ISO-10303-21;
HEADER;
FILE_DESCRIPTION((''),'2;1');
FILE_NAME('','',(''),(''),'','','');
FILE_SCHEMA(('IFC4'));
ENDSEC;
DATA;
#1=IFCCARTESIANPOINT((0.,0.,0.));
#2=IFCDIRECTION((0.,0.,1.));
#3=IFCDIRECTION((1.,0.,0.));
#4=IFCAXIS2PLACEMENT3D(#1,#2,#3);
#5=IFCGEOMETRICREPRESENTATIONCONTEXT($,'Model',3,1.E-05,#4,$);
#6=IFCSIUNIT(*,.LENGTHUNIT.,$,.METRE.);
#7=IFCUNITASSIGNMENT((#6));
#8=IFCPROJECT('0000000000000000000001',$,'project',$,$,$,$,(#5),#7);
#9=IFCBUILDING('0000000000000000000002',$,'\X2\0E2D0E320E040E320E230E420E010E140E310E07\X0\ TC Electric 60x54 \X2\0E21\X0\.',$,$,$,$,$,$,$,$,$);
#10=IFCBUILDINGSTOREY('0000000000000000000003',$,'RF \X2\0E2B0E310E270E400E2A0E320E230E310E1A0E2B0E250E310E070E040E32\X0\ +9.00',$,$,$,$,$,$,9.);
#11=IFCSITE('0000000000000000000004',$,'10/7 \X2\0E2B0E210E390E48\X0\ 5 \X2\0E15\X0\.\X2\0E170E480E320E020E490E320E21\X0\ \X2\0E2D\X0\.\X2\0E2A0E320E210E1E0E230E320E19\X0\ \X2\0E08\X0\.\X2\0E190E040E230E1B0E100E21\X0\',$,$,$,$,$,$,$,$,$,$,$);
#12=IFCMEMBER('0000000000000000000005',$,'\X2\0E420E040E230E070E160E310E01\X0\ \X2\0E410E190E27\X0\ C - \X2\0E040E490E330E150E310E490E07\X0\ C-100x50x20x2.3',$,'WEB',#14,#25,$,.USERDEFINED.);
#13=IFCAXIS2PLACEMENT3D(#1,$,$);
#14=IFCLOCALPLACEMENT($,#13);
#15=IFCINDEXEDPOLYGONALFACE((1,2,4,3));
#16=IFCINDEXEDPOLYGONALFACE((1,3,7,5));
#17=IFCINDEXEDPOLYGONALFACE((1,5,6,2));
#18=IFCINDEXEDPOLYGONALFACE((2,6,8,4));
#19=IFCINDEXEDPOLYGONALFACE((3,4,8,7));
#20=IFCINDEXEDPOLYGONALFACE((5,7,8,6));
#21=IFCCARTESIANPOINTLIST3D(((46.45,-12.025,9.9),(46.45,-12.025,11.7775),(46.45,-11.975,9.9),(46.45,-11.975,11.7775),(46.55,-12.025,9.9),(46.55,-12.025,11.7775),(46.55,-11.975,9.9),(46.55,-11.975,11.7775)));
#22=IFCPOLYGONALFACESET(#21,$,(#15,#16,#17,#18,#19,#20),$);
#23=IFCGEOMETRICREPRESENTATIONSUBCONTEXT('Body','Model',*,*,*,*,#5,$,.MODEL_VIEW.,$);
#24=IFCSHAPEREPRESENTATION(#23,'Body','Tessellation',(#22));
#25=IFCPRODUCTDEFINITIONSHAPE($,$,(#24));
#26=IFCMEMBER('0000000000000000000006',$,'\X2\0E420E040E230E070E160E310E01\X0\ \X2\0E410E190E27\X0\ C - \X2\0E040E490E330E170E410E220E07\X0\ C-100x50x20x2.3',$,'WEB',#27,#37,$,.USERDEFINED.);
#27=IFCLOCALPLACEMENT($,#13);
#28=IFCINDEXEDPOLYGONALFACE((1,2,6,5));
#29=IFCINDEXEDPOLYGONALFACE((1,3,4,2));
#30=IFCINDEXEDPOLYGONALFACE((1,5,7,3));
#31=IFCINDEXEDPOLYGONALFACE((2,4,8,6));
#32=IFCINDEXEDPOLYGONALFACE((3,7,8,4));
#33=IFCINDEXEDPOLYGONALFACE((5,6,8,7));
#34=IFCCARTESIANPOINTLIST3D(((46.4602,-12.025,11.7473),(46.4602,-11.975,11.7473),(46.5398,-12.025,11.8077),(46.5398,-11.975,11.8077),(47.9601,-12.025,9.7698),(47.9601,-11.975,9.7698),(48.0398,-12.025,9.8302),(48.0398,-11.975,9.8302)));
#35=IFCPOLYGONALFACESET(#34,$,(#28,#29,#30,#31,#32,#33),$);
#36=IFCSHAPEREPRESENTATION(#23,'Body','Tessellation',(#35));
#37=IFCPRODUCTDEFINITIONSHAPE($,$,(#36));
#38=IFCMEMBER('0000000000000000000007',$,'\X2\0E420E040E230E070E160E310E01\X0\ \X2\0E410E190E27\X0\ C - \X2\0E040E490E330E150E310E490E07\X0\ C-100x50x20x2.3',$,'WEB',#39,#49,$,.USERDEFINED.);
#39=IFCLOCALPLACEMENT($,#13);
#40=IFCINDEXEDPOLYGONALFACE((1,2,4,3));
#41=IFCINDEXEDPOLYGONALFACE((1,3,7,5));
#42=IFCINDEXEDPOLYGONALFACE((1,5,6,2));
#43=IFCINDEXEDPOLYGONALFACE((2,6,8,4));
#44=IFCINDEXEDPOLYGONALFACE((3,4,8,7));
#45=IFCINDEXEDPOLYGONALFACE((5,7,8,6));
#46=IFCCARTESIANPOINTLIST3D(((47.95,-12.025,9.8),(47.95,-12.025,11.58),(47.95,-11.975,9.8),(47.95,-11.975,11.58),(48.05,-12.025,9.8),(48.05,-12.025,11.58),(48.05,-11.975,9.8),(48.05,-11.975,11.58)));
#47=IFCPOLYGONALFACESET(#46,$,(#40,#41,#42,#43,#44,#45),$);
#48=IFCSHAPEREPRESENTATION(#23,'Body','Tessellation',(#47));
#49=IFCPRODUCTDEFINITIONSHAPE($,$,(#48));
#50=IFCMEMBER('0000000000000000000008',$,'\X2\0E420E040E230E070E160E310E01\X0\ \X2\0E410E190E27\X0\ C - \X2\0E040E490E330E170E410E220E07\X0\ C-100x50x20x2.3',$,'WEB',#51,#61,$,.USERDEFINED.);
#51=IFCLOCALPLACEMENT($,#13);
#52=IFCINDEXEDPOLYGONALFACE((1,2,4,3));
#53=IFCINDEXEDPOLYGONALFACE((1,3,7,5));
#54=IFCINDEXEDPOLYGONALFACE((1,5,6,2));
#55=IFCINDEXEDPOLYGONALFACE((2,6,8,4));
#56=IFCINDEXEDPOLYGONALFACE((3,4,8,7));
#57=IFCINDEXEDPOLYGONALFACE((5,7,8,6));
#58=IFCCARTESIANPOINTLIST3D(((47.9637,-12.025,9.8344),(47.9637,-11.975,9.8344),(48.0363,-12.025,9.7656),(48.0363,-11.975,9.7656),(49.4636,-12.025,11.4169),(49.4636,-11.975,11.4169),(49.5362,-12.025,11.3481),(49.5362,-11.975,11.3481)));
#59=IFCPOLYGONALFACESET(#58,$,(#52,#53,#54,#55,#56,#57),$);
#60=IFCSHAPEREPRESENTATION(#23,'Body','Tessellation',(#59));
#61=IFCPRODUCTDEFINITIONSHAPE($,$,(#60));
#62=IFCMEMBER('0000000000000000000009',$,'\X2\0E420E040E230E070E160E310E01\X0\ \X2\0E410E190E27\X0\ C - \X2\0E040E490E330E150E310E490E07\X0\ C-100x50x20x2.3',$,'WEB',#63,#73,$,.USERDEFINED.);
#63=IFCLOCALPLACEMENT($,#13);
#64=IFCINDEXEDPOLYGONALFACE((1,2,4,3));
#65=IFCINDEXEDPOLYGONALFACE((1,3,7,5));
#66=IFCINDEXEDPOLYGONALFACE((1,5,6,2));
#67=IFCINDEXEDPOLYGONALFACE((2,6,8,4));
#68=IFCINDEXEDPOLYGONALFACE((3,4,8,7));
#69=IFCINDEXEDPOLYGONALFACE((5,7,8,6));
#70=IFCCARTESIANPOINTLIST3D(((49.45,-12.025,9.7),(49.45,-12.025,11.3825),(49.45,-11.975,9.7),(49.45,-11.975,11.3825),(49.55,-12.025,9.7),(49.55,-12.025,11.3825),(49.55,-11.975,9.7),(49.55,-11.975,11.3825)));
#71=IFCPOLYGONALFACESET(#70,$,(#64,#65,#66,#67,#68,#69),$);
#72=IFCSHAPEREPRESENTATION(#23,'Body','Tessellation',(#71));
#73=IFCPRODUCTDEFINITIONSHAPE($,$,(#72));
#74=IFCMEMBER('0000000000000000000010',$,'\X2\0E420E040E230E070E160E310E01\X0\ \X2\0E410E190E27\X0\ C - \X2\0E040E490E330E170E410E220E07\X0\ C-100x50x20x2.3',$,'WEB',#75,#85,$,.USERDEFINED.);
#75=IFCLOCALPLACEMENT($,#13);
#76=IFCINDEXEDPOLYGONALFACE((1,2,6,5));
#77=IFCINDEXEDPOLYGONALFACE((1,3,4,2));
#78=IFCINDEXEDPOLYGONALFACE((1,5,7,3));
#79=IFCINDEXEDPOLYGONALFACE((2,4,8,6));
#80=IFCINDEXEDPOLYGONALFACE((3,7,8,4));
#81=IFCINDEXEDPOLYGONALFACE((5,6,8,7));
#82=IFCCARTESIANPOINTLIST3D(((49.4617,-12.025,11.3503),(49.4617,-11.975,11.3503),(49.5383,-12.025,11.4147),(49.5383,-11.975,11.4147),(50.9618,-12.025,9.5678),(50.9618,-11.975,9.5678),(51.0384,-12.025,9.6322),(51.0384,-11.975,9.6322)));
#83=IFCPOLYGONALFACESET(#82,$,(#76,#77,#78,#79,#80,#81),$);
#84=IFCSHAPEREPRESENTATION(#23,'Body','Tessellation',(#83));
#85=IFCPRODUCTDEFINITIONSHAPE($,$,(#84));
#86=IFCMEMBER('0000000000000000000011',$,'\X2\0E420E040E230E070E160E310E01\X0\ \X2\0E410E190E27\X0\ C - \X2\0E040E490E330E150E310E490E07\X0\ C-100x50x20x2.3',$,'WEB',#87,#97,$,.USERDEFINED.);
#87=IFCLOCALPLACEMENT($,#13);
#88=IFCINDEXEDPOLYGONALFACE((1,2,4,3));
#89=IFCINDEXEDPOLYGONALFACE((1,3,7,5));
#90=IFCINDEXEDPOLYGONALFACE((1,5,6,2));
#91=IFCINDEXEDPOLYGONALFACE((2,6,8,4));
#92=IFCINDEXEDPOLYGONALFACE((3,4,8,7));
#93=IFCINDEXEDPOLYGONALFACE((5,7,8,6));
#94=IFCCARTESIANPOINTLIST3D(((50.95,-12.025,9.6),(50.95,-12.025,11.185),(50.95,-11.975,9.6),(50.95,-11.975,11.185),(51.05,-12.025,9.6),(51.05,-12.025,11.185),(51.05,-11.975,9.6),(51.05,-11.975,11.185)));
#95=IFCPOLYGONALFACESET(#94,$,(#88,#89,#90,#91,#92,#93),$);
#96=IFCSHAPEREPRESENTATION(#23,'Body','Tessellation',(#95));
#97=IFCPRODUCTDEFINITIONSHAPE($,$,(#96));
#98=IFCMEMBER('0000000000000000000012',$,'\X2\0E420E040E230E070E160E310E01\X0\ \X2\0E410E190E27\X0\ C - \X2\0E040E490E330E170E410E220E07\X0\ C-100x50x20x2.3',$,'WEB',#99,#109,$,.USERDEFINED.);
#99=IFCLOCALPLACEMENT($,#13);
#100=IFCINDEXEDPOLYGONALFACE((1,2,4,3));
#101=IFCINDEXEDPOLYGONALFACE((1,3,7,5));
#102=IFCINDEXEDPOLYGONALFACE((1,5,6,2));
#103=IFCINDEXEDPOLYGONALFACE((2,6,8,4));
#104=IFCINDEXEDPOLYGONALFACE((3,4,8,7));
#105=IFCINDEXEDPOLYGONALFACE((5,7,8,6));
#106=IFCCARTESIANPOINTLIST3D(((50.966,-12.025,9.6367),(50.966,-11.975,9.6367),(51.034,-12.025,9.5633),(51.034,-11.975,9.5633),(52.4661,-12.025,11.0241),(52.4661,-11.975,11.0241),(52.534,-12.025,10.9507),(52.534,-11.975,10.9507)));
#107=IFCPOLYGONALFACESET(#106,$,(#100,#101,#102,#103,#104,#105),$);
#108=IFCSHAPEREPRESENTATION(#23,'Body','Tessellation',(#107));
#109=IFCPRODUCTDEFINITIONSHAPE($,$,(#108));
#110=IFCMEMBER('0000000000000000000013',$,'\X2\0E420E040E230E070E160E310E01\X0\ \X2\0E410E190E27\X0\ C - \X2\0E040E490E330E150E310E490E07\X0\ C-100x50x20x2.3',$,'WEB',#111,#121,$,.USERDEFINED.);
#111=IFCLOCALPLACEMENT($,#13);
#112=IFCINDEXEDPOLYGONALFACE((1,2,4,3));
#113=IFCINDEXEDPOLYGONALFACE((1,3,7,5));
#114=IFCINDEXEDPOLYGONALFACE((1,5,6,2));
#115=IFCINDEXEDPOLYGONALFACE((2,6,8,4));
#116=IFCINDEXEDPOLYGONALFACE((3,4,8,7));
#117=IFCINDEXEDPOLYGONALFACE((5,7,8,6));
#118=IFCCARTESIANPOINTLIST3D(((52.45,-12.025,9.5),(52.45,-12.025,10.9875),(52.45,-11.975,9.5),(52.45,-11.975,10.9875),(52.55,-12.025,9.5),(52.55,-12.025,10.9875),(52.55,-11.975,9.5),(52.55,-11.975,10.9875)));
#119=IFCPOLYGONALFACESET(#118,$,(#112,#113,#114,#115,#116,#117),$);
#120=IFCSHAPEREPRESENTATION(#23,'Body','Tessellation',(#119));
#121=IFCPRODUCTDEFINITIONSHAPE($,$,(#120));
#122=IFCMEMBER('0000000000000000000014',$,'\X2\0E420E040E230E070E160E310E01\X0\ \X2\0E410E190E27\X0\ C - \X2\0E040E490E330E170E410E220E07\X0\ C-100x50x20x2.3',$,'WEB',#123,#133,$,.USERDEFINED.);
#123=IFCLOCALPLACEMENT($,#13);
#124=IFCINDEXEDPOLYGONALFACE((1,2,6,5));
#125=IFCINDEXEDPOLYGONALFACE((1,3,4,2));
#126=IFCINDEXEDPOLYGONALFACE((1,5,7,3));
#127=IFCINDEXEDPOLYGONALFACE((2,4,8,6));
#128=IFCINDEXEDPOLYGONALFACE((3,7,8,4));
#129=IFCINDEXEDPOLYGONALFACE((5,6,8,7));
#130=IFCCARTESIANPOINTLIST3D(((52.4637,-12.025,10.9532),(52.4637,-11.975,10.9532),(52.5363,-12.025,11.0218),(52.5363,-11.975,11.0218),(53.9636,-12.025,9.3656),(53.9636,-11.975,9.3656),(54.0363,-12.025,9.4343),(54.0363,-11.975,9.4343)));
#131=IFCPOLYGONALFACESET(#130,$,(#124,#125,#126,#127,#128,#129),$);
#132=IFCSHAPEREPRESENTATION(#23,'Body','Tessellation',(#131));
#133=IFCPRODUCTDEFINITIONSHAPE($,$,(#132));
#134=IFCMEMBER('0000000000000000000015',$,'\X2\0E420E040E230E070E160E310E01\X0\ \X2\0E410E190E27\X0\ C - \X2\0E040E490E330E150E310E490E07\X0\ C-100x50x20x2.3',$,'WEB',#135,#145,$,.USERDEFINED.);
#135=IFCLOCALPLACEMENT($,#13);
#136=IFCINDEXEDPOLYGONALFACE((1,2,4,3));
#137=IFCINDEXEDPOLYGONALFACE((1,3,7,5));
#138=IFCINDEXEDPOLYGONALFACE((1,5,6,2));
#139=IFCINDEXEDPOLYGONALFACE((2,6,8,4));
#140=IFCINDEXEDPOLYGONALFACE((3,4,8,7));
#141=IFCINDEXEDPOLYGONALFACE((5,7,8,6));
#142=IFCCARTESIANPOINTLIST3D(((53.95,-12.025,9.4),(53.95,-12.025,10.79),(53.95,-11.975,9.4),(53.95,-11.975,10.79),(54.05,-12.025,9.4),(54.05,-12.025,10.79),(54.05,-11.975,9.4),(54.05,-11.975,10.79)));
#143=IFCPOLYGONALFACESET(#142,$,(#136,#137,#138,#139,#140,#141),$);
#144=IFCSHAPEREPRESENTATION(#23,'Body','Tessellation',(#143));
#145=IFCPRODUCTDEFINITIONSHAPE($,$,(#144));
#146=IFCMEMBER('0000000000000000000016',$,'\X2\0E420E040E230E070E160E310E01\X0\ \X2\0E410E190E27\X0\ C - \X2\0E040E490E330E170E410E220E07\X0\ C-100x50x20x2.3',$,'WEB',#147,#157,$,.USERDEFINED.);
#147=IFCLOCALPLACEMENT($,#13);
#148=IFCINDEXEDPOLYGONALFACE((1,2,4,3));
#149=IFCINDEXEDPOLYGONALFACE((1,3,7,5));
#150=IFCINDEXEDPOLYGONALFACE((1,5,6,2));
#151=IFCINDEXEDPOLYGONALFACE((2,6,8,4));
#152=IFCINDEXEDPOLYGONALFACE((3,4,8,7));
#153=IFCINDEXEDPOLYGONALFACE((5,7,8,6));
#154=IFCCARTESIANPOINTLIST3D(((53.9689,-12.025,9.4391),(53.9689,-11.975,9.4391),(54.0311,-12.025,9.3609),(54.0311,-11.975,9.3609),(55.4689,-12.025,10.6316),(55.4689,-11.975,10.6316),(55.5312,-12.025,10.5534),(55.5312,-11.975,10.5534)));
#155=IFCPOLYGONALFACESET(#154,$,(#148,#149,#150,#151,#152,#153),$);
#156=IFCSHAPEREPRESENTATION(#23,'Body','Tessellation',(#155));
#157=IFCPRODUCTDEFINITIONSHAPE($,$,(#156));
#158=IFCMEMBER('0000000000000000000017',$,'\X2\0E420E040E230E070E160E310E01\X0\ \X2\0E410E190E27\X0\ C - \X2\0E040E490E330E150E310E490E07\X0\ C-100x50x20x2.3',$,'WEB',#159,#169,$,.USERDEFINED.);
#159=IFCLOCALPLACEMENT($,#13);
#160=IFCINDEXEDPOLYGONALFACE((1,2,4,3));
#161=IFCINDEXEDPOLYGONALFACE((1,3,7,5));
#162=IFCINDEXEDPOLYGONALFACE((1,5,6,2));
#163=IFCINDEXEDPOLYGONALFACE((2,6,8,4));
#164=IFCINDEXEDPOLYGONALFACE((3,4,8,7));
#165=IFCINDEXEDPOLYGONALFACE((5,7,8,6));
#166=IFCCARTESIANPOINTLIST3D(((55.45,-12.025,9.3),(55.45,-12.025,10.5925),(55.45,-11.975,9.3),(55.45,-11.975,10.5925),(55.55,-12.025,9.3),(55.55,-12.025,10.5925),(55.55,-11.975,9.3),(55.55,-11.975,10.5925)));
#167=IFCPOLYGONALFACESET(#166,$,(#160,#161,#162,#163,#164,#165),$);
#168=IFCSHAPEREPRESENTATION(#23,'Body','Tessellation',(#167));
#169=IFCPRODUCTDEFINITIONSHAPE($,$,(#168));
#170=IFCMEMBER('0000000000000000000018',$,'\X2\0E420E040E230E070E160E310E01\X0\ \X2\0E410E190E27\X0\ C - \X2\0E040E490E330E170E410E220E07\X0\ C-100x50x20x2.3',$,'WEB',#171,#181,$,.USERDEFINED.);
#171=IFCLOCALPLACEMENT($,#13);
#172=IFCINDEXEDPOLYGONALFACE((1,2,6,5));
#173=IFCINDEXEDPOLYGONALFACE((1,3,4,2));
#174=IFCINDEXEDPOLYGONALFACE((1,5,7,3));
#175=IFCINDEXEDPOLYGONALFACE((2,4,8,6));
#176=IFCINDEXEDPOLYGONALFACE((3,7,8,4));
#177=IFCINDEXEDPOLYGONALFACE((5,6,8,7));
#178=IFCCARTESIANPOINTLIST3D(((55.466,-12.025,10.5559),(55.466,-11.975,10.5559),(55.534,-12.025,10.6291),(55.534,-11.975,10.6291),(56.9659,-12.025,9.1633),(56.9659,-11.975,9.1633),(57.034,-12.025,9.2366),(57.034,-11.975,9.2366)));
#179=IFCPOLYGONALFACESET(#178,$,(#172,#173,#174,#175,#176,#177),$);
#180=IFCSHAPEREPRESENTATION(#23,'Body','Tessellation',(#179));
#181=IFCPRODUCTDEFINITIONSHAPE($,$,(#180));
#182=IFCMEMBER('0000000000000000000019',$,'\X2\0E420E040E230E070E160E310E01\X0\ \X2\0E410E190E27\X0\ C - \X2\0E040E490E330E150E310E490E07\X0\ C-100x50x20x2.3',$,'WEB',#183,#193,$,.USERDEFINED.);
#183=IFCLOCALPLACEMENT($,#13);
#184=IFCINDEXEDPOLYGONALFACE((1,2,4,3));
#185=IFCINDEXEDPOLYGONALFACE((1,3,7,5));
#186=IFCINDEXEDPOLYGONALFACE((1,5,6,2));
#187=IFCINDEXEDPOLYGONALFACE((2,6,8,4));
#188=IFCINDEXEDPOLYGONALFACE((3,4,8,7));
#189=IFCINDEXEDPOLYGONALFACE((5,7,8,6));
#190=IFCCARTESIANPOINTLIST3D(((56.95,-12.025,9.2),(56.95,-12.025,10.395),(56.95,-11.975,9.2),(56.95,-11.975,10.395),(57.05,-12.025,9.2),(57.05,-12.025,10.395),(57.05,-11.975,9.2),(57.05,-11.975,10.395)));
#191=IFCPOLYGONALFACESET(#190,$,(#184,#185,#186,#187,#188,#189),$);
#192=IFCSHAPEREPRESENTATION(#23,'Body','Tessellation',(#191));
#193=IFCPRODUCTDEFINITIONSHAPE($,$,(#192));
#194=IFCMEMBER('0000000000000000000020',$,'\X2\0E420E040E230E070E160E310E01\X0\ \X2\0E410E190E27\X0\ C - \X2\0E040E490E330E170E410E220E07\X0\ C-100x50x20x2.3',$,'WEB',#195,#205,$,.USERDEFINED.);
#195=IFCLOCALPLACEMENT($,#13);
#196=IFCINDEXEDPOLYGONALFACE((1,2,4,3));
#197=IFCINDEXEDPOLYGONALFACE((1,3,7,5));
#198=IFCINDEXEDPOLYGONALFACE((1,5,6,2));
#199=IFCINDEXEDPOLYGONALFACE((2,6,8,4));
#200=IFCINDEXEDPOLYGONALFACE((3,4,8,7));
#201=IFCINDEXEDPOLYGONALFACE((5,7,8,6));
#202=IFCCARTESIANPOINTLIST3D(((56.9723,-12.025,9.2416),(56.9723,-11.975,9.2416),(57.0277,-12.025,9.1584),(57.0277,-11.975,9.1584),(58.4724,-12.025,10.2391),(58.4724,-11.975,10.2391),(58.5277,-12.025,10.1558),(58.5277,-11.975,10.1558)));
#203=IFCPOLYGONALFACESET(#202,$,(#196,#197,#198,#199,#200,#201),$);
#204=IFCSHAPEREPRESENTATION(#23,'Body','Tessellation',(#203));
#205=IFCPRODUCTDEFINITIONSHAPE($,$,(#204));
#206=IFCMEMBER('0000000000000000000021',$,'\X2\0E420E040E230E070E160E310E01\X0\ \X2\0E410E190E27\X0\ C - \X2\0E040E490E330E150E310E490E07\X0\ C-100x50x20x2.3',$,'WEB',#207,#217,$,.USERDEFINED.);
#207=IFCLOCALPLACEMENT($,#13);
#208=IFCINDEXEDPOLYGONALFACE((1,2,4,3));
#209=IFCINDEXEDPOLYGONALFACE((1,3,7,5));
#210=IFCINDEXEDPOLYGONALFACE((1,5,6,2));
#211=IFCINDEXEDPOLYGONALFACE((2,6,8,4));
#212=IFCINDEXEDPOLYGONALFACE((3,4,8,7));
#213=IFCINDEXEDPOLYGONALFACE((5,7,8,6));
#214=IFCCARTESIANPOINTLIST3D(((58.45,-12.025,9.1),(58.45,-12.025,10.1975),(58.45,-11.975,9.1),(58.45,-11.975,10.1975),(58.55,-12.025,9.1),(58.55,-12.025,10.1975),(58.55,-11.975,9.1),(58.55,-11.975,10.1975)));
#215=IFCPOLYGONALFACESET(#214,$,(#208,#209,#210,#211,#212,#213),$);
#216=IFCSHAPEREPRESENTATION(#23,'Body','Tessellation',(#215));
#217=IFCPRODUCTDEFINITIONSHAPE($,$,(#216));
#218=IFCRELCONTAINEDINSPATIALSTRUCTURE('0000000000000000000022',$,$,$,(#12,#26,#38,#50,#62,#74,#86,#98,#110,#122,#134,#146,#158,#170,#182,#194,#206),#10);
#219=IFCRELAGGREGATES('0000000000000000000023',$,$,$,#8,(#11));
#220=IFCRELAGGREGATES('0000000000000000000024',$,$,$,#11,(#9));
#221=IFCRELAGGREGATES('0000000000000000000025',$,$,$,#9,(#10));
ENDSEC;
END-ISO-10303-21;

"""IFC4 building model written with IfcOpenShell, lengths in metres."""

from ifc_helpers import new_model, si_unit, frame, origin, origin_with_axes, origin_2d, place, context, subcontext, project, spatial, rectangle, extrude, element, save


model = new_model("IFC4")

# Units and contexts
model_context = context("Model", 3, precision=1e-05, world=origin_with_axes())
body_context = subcontext(model_context, "Body", "Model", "MODEL_VIEW")
ifc_project = project(units=[si_unit("LENGTHUNIT", "METRE")], contexts=[model_context])

# Site, building, storey
site = spatial("IfcSite", under=ifc_project, Name="10/7 หมู่ 5 ต.ท่าข้าม อ.สามพราน จ.นครปฐม")
building = spatial("IfcBuilding", under=site, Name="อาคารโกดัง TC Electric 60x54 ม.")
storey = spatial("IfcBuildingStorey", under=building, Name="RF หัวเสารับหลังคา +9.00", Elevation=9.0)

# Members
member_1_placement = place(None, frame((46.5, -12.0, 9.9), z_axis=(0.0, 0.0, 1.0), x_axis=(0.0, 1.0, 0.0)))
element("IfcMember", 1, at=member_1_placement, inside=storey, Name="โครงถัก แนว C - ค้ำตั้ง C-100x50x20x2.3", ObjectType="WEB", PredefinedType="USERDEFINED", context=body_context, shape_type="SweptSolid", body=[
    extrude(rectangle(XDim=0.05, YDim=0.1, at=origin_2d()), origin(), (0.0, 0.0, 1.0), 1.8775),
])
member_2_placement = place(None, frame((46.5, -12.0, 11.7775), z_axis=(0.6043, 0.0, -0.7967), x_axis=(0.0, -1.0, 0.0)))
element("IfcMember", 2, at=member_2_placement, inside=storey, Name="โครงถัก แนว C - ค้ำทแยง C-100x50x20x2.3", ObjectType="WEB", PredefinedType="USERDEFINED", context=body_context, shape_type="SweptSolid", body=[
    extrude(rectangle(XDim=0.05, YDim=0.1, at=origin_2d()), origin(), (0.0, 0.0, 1.0), 2.482),
])
member_3_placement = place(None, frame((48.0, -12.0, 9.8), z_axis=(0.0, 0.0, 1.0), x_axis=(0.0, 1.0, 0.0)))
element("IfcMember", 3, at=member_3_placement, inside=storey, Name="โครงถัก แนว C - ค้ำตั้ง C-100x50x20x2.3", ObjectType="WEB", PredefinedType="USERDEFINED", context=body_context, shape_type="SweptSolid", body=[
    extrude(rectangle(XDim=0.05, YDim=0.1, at=origin_2d()), origin(), (0.0, 0.0, 1.0), 1.78),
])
member_4_placement = place(None, frame((48.0, -12.0, 9.8), z_axis=(0.6879, 0.0, 0.7258), x_axis=(0.0, -1.0, 0.0)))
element("IfcMember", 4, at=member_4_placement, inside=storey, Name="โครงถัก แนว C - ค้ำทแยง C-100x50x20x2.3", ObjectType="WEB", PredefinedType="USERDEFINED", context=body_context, shape_type="SweptSolid", body=[
    extrude(rectangle(XDim=0.05, YDim=0.1, at=origin_2d()), origin(), (0.0, 0.0, 1.0), 2.1804),
])
member_5_placement = place(None, frame((49.5, -12.0, 9.7), z_axis=(0.0, 0.0, 1.0), x_axis=(0.0, 1.0, 0.0)))
element("IfcMember", 5, at=member_5_placement, inside=storey, Name="โครงถัก แนว C - ค้ำตั้ง C-100x50x20x2.3", ObjectType="WEB", PredefinedType="USERDEFINED", context=body_context, shape_type="SweptSolid", body=[
    extrude(rectangle(XDim=0.05, YDim=0.1, at=origin_2d()), origin(), (0.0, 0.0, 1.0), 1.6825),
])
member_6_placement = place(None, frame((49.5, -12.0, 11.3825), z_axis=(0.6439, 0.0, -0.7651), x_axis=(0.0, -1.0, 0.0)))
element("IfcMember", 6, at=member_6_placement, inside=storey, Name="โครงถัก แนว C - ค้ำทแยง C-100x50x20x2.3", ObjectType="WEB", PredefinedType="USERDEFINED", context=body_context, shape_type="SweptSolid", body=[
    extrude(rectangle(XDim=0.05, YDim=0.1, at=origin_2d()), origin(), (0.0, 0.0, 1.0), 2.3297),
])
member_7_placement = place(None, frame((51.0, -12.0, 9.6), z_axis=(0.0, 0.0, 1.0), x_axis=(0.0, 1.0, 0.0)))
element("IfcMember", 7, at=member_7_placement, inside=storey, Name="โครงถัก แนว C - ค้ำตั้ง C-100x50x20x2.3", ObjectType="WEB", PredefinedType="USERDEFINED", context=body_context, shape_type="SweptSolid", body=[
    extrude(rectangle(XDim=0.05, YDim=0.1, at=origin_2d()), origin(), (0.0, 0.0, 1.0), 1.585),
])
member_8_placement = place(None, frame((51.0, -12.0, 9.6), z_axis=(0.7341, 0.0, 0.679), x_axis=(0.0, -1.0, 0.0)))
element("IfcMember", 8, at=member_8_placement, inside=storey, Name="โครงถัก แนว C - ค้ำทแยง C-100x50x20x2.3", ObjectType="WEB", PredefinedType="USERDEFINED", context=body_context, shape_type="SweptSolid", body=[
    extrude(rectangle(XDim=0.05, YDim=0.1, at=origin_2d()), origin(), (0.0, 0.0, 1.0), 2.0433),
])
member_9_placement = place(None, frame((52.5, -12.0, 9.5), z_axis=(0.0, 0.0, 1.0), x_axis=(0.0, 1.0, 0.0)))
element("IfcMember", 9, at=member_9_placement, inside=storey, Name="โครงถัก แนว C - ค้ำตั้ง C-100x50x20x2.3", ObjectType="WEB", PredefinedType="USERDEFINED", context=body_context, shape_type="SweptSolid", body=[
    extrude(rectangle(XDim=0.05, YDim=0.1, at=origin_2d()), origin(), (0.0, 0.0, 1.0), 1.4875),
])
member_10_placement = place(None, frame((52.5, -12.0, 10.9875), z_axis=(0.6868, 0.0, -0.7269), x_axis=(0.0, -1.0, 0.0)))
element("IfcMember", 10, at=member_10_placement, inside=storey, Name="โครงถัก แนว C - ค้ำทแยง C-100x50x20x2.3", ObjectType="WEB", PredefinedType="USERDEFINED", context=body_context, shape_type="SweptSolid", body=[
    extrude(rectangle(XDim=0.05, YDim=0.1, at=origin_2d()), origin(), (0.0, 0.0, 1.0), 2.1841),
])
member_11_placement = place(None, frame((54.0, -12.0, 9.4), z_axis=(0.0, 0.0, 1.0), x_axis=(0.0, 1.0, 0.0)))
element("IfcMember", 11, at=member_11_placement, inside=storey, Name="โครงถัก แนว C - ค้ำตั้ง C-100x50x20x2.3", ObjectType="WEB", PredefinedType="USERDEFINED", context=body_context, shape_type="SweptSolid", body=[
    extrude(rectangle(XDim=0.05, YDim=0.1, at=origin_2d()), origin(), (0.0, 0.0, 1.0), 1.39),
])
member_12_placement = place(None, frame((54.0, -12.0, 9.4), z_axis=(0.7828, 0.0, 0.6223), x_axis=(0.0, -1.0, 0.0)))
element("IfcMember", 12, at=member_12_placement, inside=storey, Name="โครงถัก แนว C - ค้ำทแยง C-100x50x20x2.3", ObjectType="WEB", PredefinedType="USERDEFINED", context=body_context, shape_type="SweptSolid", body=[
    extrude(rectangle(XDim=0.05, YDim=0.1, at=origin_2d()), origin(), (0.0, 0.0, 1.0), 1.9163),
])
member_13_placement = place(None, frame((55.5, -12.0, 9.3), z_axis=(0.0, 0.0, 1.0), x_axis=(0.0, 1.0, 0.0)))
element("IfcMember", 13, at=member_13_placement, inside=storey, Name="โครงถัก แนว C - ค้ำตั้ง C-100x50x20x2.3", ObjectType="WEB", PredefinedType="USERDEFINED", context=body_context, shape_type="SweptSolid", body=[
    extrude(rectangle(XDim=0.05, YDim=0.1, at=origin_2d()), origin(), (0.0, 0.0, 1.0), 1.2925),
])
member_14_placement = place(None, frame((55.5, -12.0, 10.5925), z_axis=(0.7329, 0.0, -0.6804), x_axis=(0.0, -1.0, 0.0)))
element("IfcMember", 14, at=member_14_placement, inside=storey, Name="โครงถัก แนว C - ค้ำทแยง C-100x50x20x2.3", ObjectType="WEB", PredefinedType="USERDEFINED", context=body_context, shape_type="SweptSolid", body=[
    extrude(rectangle(XDim=0.05, YDim=0.1, at=origin_2d()), origin(), (0.0, 0.0, 1.0), 2.0467),
])
member_15_placement = place(None, frame((57.0, -12.0, 9.2), z_axis=(0.0, 0.0, 1.0), x_axis=(0.0, 1.0, 0.0)))
element("IfcMember", 15, at=member_15_placement, inside=storey, Name="โครงถัก แนว C - ค้ำตั้ง C-100x50x20x2.3", ObjectType="WEB", PredefinedType="USERDEFINED", context=body_context, shape_type="SweptSolid", body=[
    extrude(rectangle(XDim=0.05, YDim=0.1, at=origin_2d()), origin(), (0.0, 0.0, 1.0), 1.195),
])
member_16_placement = place(None, frame((57.0, -12.0, 9.2), z_axis=(0.8327, 0.0, 0.5537), x_axis=(0.0, -1.0, 0.0)))
element("IfcMember", 16, at=member_16_placement, inside=storey, Name="โครงถัก แนว C - ค้ำทแยง C-100x50x20x2.3", ObjectType="WEB", PredefinedType="USERDEFINED", context=body_context, shape_type="SweptSolid", body=[
    extrude(rectangle(XDim=0.05, YDim=0.1, at=origin_2d()), origin(), (0.0, 0.0, 1.0), 1.8014),
])
member_17_placement = place(None, frame((58.5, -12.0, 9.1), z_axis=(0.0, 0.0, 1.0), x_axis=(0.0, 1.0, 0.0)))
element("IfcMember", 17, at=member_17_placement, inside=storey, Name="โครงถัก แนว C - ค้ำตั้ง C-100x50x20x2.3", ObjectType="WEB", PredefinedType="USERDEFINED", context=body_context, shape_type="SweptSolid", body=[
    extrude(rectangle(XDim=0.05, YDim=0.1, at=origin_2d()), origin(), (0.0, 0.0, 1.0), 1.0975),
])

save(model, "model.ifc")
